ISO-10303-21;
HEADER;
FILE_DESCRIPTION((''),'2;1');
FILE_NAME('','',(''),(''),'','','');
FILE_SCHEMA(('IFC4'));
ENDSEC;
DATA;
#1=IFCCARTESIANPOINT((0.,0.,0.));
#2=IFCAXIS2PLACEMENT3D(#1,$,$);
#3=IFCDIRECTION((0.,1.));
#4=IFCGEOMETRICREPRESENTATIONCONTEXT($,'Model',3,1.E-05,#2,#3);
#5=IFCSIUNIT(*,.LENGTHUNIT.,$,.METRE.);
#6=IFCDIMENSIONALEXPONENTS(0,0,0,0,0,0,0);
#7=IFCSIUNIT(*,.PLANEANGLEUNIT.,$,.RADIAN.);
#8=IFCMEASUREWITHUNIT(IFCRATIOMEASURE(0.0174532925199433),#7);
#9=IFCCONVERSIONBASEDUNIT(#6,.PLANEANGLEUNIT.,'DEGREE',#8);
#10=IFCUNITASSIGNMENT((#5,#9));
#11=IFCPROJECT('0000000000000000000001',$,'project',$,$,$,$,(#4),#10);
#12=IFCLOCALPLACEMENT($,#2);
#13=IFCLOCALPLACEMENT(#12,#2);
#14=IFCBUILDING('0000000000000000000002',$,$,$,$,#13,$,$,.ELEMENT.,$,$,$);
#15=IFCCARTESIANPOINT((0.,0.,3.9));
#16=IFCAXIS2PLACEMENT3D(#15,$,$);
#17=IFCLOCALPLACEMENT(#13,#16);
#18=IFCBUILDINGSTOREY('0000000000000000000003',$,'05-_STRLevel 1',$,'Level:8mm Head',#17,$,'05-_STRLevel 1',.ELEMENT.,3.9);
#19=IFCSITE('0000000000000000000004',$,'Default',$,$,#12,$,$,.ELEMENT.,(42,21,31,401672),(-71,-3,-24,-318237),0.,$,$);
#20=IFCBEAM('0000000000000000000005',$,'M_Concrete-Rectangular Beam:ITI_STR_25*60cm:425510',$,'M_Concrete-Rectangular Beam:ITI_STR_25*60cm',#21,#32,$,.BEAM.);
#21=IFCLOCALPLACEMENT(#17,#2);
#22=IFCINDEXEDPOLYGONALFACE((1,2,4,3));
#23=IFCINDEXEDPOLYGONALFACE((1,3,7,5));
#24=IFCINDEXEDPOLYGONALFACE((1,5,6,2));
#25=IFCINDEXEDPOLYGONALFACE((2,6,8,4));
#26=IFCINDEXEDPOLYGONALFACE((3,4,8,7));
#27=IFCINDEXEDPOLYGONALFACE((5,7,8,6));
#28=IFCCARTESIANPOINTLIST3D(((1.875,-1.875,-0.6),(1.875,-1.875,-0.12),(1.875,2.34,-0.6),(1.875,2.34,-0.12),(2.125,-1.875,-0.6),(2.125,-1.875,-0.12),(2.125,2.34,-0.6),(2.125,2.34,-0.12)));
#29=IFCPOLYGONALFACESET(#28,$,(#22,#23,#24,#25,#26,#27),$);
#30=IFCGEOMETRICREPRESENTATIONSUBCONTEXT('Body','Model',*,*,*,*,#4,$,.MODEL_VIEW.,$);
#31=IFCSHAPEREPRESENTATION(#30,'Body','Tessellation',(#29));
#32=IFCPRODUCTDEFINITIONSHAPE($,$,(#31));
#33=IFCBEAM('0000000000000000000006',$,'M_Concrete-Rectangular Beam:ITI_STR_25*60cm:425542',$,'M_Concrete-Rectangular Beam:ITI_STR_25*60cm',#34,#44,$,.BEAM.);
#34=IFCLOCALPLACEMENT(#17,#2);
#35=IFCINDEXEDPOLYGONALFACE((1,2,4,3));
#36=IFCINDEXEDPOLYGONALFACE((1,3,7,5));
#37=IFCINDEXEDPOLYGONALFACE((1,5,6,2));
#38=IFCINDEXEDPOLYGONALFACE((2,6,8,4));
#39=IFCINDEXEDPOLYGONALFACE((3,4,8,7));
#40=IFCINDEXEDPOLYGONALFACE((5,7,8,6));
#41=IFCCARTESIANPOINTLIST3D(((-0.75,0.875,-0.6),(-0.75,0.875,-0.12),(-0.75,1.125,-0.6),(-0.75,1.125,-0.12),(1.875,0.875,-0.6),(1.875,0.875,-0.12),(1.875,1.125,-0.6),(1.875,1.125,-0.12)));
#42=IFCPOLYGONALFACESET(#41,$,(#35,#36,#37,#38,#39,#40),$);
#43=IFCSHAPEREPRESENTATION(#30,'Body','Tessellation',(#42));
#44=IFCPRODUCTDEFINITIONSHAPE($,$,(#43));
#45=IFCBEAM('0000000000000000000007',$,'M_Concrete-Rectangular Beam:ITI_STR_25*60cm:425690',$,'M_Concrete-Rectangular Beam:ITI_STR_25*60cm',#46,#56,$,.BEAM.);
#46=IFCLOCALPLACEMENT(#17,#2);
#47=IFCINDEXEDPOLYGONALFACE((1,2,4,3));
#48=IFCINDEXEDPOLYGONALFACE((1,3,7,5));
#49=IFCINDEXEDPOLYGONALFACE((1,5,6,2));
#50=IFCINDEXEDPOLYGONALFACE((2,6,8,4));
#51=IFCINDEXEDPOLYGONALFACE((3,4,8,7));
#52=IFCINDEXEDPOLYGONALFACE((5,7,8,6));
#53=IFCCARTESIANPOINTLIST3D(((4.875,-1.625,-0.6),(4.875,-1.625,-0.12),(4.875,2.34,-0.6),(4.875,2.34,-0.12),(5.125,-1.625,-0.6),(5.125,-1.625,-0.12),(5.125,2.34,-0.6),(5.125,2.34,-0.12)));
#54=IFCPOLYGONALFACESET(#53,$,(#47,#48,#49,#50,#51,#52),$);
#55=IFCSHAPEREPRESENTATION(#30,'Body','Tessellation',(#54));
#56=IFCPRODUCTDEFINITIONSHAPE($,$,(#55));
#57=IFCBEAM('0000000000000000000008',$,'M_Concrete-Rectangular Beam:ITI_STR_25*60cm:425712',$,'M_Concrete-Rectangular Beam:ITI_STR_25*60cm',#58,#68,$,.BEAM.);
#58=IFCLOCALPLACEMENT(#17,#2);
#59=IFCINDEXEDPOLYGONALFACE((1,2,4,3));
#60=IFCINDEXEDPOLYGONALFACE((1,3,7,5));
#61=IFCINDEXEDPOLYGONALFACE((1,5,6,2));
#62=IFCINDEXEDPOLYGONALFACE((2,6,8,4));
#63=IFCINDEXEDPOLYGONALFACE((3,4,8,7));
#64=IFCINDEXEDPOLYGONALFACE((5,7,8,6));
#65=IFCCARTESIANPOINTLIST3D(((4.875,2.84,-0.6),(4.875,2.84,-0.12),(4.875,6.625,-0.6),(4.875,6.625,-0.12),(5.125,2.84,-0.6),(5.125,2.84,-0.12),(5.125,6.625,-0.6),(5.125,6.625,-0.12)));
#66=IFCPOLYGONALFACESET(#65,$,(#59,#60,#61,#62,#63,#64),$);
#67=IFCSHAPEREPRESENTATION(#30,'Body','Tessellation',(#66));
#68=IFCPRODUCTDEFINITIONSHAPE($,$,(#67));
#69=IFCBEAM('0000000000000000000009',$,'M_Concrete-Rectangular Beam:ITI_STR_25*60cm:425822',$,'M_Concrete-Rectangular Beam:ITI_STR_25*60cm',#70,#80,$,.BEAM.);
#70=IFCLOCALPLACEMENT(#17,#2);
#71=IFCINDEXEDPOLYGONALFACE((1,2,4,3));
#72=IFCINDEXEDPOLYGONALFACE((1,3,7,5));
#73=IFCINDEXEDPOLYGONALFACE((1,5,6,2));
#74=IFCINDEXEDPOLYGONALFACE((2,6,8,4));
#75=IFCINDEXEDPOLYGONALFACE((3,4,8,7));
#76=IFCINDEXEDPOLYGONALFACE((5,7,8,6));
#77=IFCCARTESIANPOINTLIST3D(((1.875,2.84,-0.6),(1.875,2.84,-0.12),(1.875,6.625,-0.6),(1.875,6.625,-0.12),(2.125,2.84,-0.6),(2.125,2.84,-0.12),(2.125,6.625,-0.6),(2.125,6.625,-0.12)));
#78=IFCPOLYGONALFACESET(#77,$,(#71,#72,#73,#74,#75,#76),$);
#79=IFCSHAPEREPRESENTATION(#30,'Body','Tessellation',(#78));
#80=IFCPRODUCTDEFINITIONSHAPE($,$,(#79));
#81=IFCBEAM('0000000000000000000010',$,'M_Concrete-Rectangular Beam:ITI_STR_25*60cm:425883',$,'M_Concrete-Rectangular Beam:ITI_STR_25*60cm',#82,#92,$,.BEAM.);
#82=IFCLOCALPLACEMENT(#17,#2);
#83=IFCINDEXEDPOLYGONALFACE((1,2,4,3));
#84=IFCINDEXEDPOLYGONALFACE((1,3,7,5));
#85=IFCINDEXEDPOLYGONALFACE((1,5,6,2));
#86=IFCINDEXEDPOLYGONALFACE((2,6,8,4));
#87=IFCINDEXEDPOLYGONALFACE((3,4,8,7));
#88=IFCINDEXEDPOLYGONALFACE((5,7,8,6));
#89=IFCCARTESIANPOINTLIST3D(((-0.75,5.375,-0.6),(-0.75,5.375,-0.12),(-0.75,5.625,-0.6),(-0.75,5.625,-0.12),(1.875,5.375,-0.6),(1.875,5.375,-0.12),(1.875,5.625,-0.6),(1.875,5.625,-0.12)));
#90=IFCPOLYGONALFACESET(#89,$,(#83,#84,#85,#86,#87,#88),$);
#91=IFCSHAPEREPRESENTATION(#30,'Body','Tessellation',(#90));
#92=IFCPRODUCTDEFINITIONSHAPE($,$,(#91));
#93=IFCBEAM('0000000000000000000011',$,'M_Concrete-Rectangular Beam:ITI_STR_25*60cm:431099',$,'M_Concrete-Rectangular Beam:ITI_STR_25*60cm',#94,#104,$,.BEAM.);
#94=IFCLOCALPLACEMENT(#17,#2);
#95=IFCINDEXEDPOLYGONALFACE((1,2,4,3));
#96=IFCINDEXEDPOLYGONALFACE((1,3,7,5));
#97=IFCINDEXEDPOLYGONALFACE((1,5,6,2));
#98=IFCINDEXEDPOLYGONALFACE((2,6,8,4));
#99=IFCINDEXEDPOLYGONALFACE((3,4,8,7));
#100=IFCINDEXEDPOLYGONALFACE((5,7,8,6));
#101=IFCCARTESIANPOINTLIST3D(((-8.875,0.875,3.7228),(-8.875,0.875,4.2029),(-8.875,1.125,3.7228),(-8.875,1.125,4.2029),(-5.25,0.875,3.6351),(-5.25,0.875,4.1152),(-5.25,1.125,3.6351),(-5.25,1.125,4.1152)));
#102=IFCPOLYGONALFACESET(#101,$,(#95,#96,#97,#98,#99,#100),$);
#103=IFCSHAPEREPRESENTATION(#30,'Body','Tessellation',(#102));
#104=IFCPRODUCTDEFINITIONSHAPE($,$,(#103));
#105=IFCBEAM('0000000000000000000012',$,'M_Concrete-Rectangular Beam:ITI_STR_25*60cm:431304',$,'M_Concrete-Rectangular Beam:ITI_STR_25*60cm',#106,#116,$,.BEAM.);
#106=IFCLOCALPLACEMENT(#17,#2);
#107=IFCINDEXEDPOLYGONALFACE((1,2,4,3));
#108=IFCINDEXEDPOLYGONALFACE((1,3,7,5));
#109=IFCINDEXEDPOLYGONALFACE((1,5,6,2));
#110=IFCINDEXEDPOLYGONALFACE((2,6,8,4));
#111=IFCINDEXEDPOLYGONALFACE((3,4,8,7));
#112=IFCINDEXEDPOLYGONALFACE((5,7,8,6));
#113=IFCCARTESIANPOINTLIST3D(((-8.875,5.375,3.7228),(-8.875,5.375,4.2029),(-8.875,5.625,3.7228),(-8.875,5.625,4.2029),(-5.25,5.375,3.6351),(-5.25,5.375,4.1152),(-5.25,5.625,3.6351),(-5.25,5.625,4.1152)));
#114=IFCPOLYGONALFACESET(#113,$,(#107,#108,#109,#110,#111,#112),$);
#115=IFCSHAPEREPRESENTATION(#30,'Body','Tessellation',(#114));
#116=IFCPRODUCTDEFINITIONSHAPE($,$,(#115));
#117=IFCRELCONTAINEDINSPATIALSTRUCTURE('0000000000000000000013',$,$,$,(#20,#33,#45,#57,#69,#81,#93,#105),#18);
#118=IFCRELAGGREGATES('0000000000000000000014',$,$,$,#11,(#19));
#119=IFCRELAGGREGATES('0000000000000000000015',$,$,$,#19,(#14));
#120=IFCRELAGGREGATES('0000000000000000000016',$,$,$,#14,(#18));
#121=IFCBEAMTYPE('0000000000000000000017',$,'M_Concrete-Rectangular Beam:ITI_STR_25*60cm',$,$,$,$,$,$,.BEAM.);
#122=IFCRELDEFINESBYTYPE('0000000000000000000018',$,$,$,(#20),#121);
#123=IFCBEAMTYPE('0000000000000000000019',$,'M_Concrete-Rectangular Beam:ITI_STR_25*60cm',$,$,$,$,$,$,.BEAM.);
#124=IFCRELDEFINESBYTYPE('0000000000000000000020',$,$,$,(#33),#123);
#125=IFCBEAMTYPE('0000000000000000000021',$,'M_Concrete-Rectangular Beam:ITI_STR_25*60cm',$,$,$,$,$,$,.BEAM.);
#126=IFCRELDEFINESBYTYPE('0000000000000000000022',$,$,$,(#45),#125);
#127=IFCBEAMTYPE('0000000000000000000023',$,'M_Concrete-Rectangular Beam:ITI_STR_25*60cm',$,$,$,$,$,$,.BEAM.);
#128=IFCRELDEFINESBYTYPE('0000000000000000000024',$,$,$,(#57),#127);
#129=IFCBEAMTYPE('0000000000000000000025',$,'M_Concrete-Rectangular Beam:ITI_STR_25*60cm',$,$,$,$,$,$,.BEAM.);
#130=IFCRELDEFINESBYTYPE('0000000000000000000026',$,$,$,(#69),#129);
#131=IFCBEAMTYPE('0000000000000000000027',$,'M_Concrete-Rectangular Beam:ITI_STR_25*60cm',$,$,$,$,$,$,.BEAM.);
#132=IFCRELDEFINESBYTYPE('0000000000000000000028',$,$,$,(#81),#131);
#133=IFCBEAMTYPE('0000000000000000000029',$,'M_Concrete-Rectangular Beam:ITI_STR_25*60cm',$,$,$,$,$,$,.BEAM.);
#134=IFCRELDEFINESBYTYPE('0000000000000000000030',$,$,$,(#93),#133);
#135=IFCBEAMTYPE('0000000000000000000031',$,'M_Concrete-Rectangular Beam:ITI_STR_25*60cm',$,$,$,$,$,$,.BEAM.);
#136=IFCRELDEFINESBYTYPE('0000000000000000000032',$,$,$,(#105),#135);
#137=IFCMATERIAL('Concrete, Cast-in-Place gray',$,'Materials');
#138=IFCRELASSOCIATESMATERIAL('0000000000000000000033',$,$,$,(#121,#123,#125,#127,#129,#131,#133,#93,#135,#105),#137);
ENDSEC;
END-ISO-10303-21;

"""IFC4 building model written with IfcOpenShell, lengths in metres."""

from ifc_helpers import new_model, entity, si_unit, converted_unit, direction, frame, origin, place, context, subcontext, project, spatial, indexed_curve, outline, extrude, source, transform, mapped, material, type_object, type_shapes, element, save


model = new_model("IFC4")

# Units and contexts
model_context = context("Model", 3, precision=1e-05, world=origin(), true_north=direction((0.0, 1.0)))
body_context = subcontext(model_context, "Body", "Model", "MODEL_VIEW")
ifc_project = project(units=[si_unit("LENGTHUNIT", "METRE"), converted_unit("PLANEANGLEUNIT", "DEGREE", entity("IfcRatioMeasure", 0.0174532925199433), si_unit("PLANEANGLEUNIT", "RADIAN"), dimensions=[0, 0, 0, 0, 0, 0, 0])], contexts=[model_context])

# Site, building, storey
site_placement = place(None, origin())
site = spatial("IfcSite", under=ifc_project, at=site_placement, Name="Default", CompositionType="ELEMENT", RefLatitude=(42, 21, 31, 401672), RefLongitude=(-71, -3, -24, -318237), RefElevation=0.0)
building_placement = place(site_placement, origin())
building = spatial("IfcBuilding", under=site, at=building_placement, CompositionType="ELEMENT")
storey_placement = place(building_placement, frame((0.0, 0.0, 3.9)))
storey = spatial("IfcBuildingStorey", under=building, at=storey_placement, Name="05-_STRLevel 1", ObjectType="Level:8mm Head", LongName="05-_STRLevel 1", CompositionType="ELEMENT", Elevation=3.9)

# Shared definitions
ifc_material_1 = material(Name="Concrete, Cast-in-Place gray", Category="Materials")

# Beams
beam_type_1 = type_object("IfcBeamType", Name="M_Concrete-Rectangular Beam:ITI_STR_25*60cm", PredefinedType="BEAM", material=ifc_material_1)
shared_shape_1 = source(origin(), body_context, "Body", "SweptSolid", [
    extrude(outline(indexed_curve([(-0.125, -0.24), (0.125, -0.24), (0.125, 0.24), (-0.125, 0.24), (-0.125, -0.24)], self_intersect=False)), frame((2.0, 2.34, 3.54), z_axis=(0.0, -1.0, 0.0), x_axis=(-1.0, 0.0, 0.0)), (0.0, 0.0, 1.0), 4.215),
])
type_shapes(beam_type_1, [shared_shape_1])
beam_1_placement = place(storey_placement, frame((0.0, 0.0, -3.9)))
element("IfcBeam", 1, at=beam_1_placement, inside=storey, type_object=beam_type_1, Name="M_Concrete-Rectangular Beam:ITI_STR_25*60cm:425510", ObjectType="M_Concrete-Rectangular Beam:ITI_STR_25*60cm", PredefinedType="BEAM", context=body_context, shape_type="MappedRepresentation", body=[
    mapped(shared_shape_1, transform((0.0, 0.0, 0.0), scale=1.0)),
])
beam_type_2 = type_object("IfcBeamType", Name="M_Concrete-Rectangular Beam:ITI_STR_25*60cm", PredefinedType="BEAM", material=ifc_material_1)
shared_shape_2 = source(origin(), body_context, "Body", "SweptSolid", [
    extrude(outline(indexed_curve([(-0.24, -0.125), (0.24, -0.125), (0.24, 0.125), (-0.24, 0.125), (-0.24, -0.125)], self_intersect=False)), frame((-0.75, 1.0, 3.54), z_axis=(1.0, 0.0, 0.0), x_axis=(0.0, 0.0, -1.0)), (0.0, 0.0, 1.0), 2.625),
])
type_shapes(beam_type_2, [shared_shape_2])
beam_2_placement = place(storey_placement, frame((0.0, 0.0, -3.9)))
element("IfcBeam", 2, at=beam_2_placement, inside=storey, type_object=beam_type_2, Name="M_Concrete-Rectangular Beam:ITI_STR_25*60cm:425542", ObjectType="M_Concrete-Rectangular Beam:ITI_STR_25*60cm", PredefinedType="BEAM", context=body_context, shape_type="MappedRepresentation", body=[
    mapped(shared_shape_2, transform((0.0, 0.0, 0.0), scale=1.0)),
])
beam_type_3 = type_object("IfcBeamType", Name="M_Concrete-Rectangular Beam:ITI_STR_25*60cm", PredefinedType="BEAM", material=ifc_material_1)
shared_shape_3 = source(origin(), body_context, "Body", "SweptSolid", [
    extrude(outline(indexed_curve([(-0.125, -0.24), (0.125, -0.24), (0.125, 0.24), (-0.125, 0.24), (-0.125, -0.24)], self_intersect=False)), frame((5.0, -1.625, 3.54), z_axis=(0.0, 1.0, 0.0), x_axis=(-1.0, 0.0, 0.0)), (0.0, 0.0, 1.0), 3.965),
])
type_shapes(beam_type_3, [shared_shape_3])
beam_3_placement = place(storey_placement, frame((0.0, 0.0, -3.9)))
element("IfcBeam", 3, at=beam_3_placement, inside=storey, type_object=beam_type_3, Name="M_Concrete-Rectangular Beam:ITI_STR_25*60cm:425690", ObjectType="M_Concrete-Rectangular Beam:ITI_STR_25*60cm", PredefinedType="BEAM", context=body_context, shape_type="MappedRepresentation", body=[
    mapped(shared_shape_3, transform((0.0, 0.0, 0.0), scale=1.0)),
])
beam_type_4 = type_object("IfcBeamType", Name="M_Concrete-Rectangular Beam:ITI_STR_25*60cm", PredefinedType="BEAM", material=ifc_material_1)
shared_shape_4 = source(origin(), body_context, "Body", "SweptSolid", [
    extrude(outline(indexed_curve([(-0.125, -0.24), (0.125, -0.24), (0.125, 0.24), (-0.125, 0.24), (-0.125, -0.24)], self_intersect=False)), frame((5.0, 2.84, 3.54), z_axis=(0.0, 1.0, 0.0), x_axis=(-1.0, 0.0, 0.0)), (0.0, 0.0, 1.0), 3.785),
])
type_shapes(beam_type_4, [shared_shape_4])
beam_4_placement = place(storey_placement, frame((0.0, 0.0, -3.9)))
element("IfcBeam", 4, at=beam_4_placement, inside=storey, type_object=beam_type_4, Name="M_Concrete-Rectangular Beam:ITI_STR_25*60cm:425712", ObjectType="M_Concrete-Rectangular Beam:ITI_STR_25*60cm", PredefinedType="BEAM", context=body_context, shape_type="MappedRepresentation", body=[
    mapped(shared_shape_4, transform((0.0, 0.0, 0.0), scale=1.0)),
])
beam_type_5 = type_object("IfcBeamType", Name="M_Concrete-Rectangular Beam:ITI_STR_25*60cm", PredefinedType="BEAM", material=ifc_material_1)
shared_shape_5 = source(origin(), body_context, "Body", "SweptSolid", [
    extrude(outline(indexed_curve([(-0.125, -0.24), (0.125, -0.24), (0.125, 0.24), (-0.125, 0.24), (-0.125, -0.24)], self_intersect=False)), frame((2.0, 6.625, 3.54), z_axis=(0.0, -1.0, 0.0), x_axis=(-1.0, 0.0, 0.0)), (0.0, 0.0, 1.0), 3.785),
])
type_shapes(beam_type_5, [shared_shape_5])
beam_5_placement = place(storey_placement, frame((0.0, 0.0, -3.9)))
element("IfcBeam", 5, at=beam_5_placement, inside=storey, type_object=beam_type_5, Name="M_Concrete-Rectangular Beam:ITI_STR_25*60cm:425822", ObjectType="M_Concrete-Rectangular Beam:ITI_STR_25*60cm", PredefinedType="BEAM", context=body_context, shape_type="MappedRepresentation", body=[
    mapped(shared_shape_5, transform((0.0, 0.0, 0.0), scale=1.0)),
])
beam_type_6 = type_object("IfcBeamType", Name="M_Concrete-Rectangular Beam:ITI_STR_25*60cm", PredefinedType="BEAM", material=ifc_material_1)
shared_shape_6 = source(origin(), body_context, "Body", "SweptSolid", [
    extrude(outline(indexed_curve([(-0.24, -0.125), (0.24, -0.125), (0.24, 0.125), (-0.24, 0.125), (-0.24, -0.125)], self_intersect=False)), frame((-0.75, 5.5, 3.54), z_axis=(1.0, 0.0, 0.0), x_axis=(0.0, 0.0, -1.0)), (0.0, 0.0, 1.0), 2.625),
])
type_shapes(beam_type_6, [shared_shape_6])
beam_6_placement = place(storey_placement, frame((0.0, 0.0, -3.9)))
element("IfcBeam", 6, at=beam_6_placement, inside=storey, type_object=beam_type_6, Name="M_Concrete-Rectangular Beam:ITI_STR_25*60cm:425883", ObjectType="M_Concrete-Rectangular Beam:ITI_STR_25*60cm", PredefinedType="BEAM", context=body_context, shape_type="MappedRepresentation", body=[
    mapped(shared_shape_6, transform((0.0, 0.0, 0.0), scale=1.0)),
])
beam_type_7 = type_object("IfcBeamType", Name="M_Concrete-Rectangular Beam:ITI_STR_25*60cm", PredefinedType="BEAM", material=ifc_material_1)
shared_shape_7 = source(origin(), body_context, "Body", "SweptSolid", [
    extrude(outline(indexed_curve([(-1.8188, -0.24), (1.8072, -0.24), (1.8188, 0.24), (-1.8072, 0.24), (-1.8188, -0.24)], self_intersect=False)), frame((-7.0625, 0.875, 7.819), z_axis=(0.0, 1.0, 0.0), x_axis=(-0.999707, 0.0, 0.024186)), (0.0, 0.0, 1.0), 0.25),
])
type_shapes(beam_type_7, [shared_shape_7])
beam_7_placement = place(storey_placement, frame((0.0, 0.0, -3.9)))
element("IfcBeam", 7, at=beam_7_placement, inside=storey, type_object=beam_type_7, material=ifc_material_1, Name="M_Concrete-Rectangular Beam:ITI_STR_25*60cm:431099", ObjectType="M_Concrete-Rectangular Beam:ITI_STR_25*60cm", PredefinedType="BEAM", context=body_context, shape_type="MappedRepresentation", body=[
    mapped(shared_shape_7, transform((0.0, 0.0, 0.0), scale=1.0)),
])
beam_type_8 = type_object("IfcBeamType", Name="M_Concrete-Rectangular Beam:ITI_STR_25*60cm", PredefinedType="BEAM", material=ifc_material_1)
shared_shape_8 = source(origin(), body_context, "Body", "SweptSolid", [
    extrude(outline(indexed_curve([(-1.8188, -0.24), (1.8072, -0.24), (1.8188, 0.24), (-1.8072, 0.24), (-1.8188, -0.24)], self_intersect=False)), frame((-7.0625, 5.375, 7.819), z_axis=(0.0, 1.0, 0.0), x_axis=(-0.999707, 0.0, 0.024186)), (0.0, 0.0, 1.0), 0.25),
])
type_shapes(beam_type_8, [shared_shape_8])
beam_8_placement = place(storey_placement, frame((0.0, 0.0, -3.9)))
element("IfcBeam", 8, at=beam_8_placement, inside=storey, type_object=beam_type_8, material=ifc_material_1, Name="M_Concrete-Rectangular Beam:ITI_STR_25*60cm:431304", ObjectType="M_Concrete-Rectangular Beam:ITI_STR_25*60cm", PredefinedType="BEAM", context=body_context, shape_type="MappedRepresentation", body=[
    mapped(shared_shape_8, transform((0.0, 0.0, 0.0), scale=1.0)),
])

save(model, "model.ifc")
